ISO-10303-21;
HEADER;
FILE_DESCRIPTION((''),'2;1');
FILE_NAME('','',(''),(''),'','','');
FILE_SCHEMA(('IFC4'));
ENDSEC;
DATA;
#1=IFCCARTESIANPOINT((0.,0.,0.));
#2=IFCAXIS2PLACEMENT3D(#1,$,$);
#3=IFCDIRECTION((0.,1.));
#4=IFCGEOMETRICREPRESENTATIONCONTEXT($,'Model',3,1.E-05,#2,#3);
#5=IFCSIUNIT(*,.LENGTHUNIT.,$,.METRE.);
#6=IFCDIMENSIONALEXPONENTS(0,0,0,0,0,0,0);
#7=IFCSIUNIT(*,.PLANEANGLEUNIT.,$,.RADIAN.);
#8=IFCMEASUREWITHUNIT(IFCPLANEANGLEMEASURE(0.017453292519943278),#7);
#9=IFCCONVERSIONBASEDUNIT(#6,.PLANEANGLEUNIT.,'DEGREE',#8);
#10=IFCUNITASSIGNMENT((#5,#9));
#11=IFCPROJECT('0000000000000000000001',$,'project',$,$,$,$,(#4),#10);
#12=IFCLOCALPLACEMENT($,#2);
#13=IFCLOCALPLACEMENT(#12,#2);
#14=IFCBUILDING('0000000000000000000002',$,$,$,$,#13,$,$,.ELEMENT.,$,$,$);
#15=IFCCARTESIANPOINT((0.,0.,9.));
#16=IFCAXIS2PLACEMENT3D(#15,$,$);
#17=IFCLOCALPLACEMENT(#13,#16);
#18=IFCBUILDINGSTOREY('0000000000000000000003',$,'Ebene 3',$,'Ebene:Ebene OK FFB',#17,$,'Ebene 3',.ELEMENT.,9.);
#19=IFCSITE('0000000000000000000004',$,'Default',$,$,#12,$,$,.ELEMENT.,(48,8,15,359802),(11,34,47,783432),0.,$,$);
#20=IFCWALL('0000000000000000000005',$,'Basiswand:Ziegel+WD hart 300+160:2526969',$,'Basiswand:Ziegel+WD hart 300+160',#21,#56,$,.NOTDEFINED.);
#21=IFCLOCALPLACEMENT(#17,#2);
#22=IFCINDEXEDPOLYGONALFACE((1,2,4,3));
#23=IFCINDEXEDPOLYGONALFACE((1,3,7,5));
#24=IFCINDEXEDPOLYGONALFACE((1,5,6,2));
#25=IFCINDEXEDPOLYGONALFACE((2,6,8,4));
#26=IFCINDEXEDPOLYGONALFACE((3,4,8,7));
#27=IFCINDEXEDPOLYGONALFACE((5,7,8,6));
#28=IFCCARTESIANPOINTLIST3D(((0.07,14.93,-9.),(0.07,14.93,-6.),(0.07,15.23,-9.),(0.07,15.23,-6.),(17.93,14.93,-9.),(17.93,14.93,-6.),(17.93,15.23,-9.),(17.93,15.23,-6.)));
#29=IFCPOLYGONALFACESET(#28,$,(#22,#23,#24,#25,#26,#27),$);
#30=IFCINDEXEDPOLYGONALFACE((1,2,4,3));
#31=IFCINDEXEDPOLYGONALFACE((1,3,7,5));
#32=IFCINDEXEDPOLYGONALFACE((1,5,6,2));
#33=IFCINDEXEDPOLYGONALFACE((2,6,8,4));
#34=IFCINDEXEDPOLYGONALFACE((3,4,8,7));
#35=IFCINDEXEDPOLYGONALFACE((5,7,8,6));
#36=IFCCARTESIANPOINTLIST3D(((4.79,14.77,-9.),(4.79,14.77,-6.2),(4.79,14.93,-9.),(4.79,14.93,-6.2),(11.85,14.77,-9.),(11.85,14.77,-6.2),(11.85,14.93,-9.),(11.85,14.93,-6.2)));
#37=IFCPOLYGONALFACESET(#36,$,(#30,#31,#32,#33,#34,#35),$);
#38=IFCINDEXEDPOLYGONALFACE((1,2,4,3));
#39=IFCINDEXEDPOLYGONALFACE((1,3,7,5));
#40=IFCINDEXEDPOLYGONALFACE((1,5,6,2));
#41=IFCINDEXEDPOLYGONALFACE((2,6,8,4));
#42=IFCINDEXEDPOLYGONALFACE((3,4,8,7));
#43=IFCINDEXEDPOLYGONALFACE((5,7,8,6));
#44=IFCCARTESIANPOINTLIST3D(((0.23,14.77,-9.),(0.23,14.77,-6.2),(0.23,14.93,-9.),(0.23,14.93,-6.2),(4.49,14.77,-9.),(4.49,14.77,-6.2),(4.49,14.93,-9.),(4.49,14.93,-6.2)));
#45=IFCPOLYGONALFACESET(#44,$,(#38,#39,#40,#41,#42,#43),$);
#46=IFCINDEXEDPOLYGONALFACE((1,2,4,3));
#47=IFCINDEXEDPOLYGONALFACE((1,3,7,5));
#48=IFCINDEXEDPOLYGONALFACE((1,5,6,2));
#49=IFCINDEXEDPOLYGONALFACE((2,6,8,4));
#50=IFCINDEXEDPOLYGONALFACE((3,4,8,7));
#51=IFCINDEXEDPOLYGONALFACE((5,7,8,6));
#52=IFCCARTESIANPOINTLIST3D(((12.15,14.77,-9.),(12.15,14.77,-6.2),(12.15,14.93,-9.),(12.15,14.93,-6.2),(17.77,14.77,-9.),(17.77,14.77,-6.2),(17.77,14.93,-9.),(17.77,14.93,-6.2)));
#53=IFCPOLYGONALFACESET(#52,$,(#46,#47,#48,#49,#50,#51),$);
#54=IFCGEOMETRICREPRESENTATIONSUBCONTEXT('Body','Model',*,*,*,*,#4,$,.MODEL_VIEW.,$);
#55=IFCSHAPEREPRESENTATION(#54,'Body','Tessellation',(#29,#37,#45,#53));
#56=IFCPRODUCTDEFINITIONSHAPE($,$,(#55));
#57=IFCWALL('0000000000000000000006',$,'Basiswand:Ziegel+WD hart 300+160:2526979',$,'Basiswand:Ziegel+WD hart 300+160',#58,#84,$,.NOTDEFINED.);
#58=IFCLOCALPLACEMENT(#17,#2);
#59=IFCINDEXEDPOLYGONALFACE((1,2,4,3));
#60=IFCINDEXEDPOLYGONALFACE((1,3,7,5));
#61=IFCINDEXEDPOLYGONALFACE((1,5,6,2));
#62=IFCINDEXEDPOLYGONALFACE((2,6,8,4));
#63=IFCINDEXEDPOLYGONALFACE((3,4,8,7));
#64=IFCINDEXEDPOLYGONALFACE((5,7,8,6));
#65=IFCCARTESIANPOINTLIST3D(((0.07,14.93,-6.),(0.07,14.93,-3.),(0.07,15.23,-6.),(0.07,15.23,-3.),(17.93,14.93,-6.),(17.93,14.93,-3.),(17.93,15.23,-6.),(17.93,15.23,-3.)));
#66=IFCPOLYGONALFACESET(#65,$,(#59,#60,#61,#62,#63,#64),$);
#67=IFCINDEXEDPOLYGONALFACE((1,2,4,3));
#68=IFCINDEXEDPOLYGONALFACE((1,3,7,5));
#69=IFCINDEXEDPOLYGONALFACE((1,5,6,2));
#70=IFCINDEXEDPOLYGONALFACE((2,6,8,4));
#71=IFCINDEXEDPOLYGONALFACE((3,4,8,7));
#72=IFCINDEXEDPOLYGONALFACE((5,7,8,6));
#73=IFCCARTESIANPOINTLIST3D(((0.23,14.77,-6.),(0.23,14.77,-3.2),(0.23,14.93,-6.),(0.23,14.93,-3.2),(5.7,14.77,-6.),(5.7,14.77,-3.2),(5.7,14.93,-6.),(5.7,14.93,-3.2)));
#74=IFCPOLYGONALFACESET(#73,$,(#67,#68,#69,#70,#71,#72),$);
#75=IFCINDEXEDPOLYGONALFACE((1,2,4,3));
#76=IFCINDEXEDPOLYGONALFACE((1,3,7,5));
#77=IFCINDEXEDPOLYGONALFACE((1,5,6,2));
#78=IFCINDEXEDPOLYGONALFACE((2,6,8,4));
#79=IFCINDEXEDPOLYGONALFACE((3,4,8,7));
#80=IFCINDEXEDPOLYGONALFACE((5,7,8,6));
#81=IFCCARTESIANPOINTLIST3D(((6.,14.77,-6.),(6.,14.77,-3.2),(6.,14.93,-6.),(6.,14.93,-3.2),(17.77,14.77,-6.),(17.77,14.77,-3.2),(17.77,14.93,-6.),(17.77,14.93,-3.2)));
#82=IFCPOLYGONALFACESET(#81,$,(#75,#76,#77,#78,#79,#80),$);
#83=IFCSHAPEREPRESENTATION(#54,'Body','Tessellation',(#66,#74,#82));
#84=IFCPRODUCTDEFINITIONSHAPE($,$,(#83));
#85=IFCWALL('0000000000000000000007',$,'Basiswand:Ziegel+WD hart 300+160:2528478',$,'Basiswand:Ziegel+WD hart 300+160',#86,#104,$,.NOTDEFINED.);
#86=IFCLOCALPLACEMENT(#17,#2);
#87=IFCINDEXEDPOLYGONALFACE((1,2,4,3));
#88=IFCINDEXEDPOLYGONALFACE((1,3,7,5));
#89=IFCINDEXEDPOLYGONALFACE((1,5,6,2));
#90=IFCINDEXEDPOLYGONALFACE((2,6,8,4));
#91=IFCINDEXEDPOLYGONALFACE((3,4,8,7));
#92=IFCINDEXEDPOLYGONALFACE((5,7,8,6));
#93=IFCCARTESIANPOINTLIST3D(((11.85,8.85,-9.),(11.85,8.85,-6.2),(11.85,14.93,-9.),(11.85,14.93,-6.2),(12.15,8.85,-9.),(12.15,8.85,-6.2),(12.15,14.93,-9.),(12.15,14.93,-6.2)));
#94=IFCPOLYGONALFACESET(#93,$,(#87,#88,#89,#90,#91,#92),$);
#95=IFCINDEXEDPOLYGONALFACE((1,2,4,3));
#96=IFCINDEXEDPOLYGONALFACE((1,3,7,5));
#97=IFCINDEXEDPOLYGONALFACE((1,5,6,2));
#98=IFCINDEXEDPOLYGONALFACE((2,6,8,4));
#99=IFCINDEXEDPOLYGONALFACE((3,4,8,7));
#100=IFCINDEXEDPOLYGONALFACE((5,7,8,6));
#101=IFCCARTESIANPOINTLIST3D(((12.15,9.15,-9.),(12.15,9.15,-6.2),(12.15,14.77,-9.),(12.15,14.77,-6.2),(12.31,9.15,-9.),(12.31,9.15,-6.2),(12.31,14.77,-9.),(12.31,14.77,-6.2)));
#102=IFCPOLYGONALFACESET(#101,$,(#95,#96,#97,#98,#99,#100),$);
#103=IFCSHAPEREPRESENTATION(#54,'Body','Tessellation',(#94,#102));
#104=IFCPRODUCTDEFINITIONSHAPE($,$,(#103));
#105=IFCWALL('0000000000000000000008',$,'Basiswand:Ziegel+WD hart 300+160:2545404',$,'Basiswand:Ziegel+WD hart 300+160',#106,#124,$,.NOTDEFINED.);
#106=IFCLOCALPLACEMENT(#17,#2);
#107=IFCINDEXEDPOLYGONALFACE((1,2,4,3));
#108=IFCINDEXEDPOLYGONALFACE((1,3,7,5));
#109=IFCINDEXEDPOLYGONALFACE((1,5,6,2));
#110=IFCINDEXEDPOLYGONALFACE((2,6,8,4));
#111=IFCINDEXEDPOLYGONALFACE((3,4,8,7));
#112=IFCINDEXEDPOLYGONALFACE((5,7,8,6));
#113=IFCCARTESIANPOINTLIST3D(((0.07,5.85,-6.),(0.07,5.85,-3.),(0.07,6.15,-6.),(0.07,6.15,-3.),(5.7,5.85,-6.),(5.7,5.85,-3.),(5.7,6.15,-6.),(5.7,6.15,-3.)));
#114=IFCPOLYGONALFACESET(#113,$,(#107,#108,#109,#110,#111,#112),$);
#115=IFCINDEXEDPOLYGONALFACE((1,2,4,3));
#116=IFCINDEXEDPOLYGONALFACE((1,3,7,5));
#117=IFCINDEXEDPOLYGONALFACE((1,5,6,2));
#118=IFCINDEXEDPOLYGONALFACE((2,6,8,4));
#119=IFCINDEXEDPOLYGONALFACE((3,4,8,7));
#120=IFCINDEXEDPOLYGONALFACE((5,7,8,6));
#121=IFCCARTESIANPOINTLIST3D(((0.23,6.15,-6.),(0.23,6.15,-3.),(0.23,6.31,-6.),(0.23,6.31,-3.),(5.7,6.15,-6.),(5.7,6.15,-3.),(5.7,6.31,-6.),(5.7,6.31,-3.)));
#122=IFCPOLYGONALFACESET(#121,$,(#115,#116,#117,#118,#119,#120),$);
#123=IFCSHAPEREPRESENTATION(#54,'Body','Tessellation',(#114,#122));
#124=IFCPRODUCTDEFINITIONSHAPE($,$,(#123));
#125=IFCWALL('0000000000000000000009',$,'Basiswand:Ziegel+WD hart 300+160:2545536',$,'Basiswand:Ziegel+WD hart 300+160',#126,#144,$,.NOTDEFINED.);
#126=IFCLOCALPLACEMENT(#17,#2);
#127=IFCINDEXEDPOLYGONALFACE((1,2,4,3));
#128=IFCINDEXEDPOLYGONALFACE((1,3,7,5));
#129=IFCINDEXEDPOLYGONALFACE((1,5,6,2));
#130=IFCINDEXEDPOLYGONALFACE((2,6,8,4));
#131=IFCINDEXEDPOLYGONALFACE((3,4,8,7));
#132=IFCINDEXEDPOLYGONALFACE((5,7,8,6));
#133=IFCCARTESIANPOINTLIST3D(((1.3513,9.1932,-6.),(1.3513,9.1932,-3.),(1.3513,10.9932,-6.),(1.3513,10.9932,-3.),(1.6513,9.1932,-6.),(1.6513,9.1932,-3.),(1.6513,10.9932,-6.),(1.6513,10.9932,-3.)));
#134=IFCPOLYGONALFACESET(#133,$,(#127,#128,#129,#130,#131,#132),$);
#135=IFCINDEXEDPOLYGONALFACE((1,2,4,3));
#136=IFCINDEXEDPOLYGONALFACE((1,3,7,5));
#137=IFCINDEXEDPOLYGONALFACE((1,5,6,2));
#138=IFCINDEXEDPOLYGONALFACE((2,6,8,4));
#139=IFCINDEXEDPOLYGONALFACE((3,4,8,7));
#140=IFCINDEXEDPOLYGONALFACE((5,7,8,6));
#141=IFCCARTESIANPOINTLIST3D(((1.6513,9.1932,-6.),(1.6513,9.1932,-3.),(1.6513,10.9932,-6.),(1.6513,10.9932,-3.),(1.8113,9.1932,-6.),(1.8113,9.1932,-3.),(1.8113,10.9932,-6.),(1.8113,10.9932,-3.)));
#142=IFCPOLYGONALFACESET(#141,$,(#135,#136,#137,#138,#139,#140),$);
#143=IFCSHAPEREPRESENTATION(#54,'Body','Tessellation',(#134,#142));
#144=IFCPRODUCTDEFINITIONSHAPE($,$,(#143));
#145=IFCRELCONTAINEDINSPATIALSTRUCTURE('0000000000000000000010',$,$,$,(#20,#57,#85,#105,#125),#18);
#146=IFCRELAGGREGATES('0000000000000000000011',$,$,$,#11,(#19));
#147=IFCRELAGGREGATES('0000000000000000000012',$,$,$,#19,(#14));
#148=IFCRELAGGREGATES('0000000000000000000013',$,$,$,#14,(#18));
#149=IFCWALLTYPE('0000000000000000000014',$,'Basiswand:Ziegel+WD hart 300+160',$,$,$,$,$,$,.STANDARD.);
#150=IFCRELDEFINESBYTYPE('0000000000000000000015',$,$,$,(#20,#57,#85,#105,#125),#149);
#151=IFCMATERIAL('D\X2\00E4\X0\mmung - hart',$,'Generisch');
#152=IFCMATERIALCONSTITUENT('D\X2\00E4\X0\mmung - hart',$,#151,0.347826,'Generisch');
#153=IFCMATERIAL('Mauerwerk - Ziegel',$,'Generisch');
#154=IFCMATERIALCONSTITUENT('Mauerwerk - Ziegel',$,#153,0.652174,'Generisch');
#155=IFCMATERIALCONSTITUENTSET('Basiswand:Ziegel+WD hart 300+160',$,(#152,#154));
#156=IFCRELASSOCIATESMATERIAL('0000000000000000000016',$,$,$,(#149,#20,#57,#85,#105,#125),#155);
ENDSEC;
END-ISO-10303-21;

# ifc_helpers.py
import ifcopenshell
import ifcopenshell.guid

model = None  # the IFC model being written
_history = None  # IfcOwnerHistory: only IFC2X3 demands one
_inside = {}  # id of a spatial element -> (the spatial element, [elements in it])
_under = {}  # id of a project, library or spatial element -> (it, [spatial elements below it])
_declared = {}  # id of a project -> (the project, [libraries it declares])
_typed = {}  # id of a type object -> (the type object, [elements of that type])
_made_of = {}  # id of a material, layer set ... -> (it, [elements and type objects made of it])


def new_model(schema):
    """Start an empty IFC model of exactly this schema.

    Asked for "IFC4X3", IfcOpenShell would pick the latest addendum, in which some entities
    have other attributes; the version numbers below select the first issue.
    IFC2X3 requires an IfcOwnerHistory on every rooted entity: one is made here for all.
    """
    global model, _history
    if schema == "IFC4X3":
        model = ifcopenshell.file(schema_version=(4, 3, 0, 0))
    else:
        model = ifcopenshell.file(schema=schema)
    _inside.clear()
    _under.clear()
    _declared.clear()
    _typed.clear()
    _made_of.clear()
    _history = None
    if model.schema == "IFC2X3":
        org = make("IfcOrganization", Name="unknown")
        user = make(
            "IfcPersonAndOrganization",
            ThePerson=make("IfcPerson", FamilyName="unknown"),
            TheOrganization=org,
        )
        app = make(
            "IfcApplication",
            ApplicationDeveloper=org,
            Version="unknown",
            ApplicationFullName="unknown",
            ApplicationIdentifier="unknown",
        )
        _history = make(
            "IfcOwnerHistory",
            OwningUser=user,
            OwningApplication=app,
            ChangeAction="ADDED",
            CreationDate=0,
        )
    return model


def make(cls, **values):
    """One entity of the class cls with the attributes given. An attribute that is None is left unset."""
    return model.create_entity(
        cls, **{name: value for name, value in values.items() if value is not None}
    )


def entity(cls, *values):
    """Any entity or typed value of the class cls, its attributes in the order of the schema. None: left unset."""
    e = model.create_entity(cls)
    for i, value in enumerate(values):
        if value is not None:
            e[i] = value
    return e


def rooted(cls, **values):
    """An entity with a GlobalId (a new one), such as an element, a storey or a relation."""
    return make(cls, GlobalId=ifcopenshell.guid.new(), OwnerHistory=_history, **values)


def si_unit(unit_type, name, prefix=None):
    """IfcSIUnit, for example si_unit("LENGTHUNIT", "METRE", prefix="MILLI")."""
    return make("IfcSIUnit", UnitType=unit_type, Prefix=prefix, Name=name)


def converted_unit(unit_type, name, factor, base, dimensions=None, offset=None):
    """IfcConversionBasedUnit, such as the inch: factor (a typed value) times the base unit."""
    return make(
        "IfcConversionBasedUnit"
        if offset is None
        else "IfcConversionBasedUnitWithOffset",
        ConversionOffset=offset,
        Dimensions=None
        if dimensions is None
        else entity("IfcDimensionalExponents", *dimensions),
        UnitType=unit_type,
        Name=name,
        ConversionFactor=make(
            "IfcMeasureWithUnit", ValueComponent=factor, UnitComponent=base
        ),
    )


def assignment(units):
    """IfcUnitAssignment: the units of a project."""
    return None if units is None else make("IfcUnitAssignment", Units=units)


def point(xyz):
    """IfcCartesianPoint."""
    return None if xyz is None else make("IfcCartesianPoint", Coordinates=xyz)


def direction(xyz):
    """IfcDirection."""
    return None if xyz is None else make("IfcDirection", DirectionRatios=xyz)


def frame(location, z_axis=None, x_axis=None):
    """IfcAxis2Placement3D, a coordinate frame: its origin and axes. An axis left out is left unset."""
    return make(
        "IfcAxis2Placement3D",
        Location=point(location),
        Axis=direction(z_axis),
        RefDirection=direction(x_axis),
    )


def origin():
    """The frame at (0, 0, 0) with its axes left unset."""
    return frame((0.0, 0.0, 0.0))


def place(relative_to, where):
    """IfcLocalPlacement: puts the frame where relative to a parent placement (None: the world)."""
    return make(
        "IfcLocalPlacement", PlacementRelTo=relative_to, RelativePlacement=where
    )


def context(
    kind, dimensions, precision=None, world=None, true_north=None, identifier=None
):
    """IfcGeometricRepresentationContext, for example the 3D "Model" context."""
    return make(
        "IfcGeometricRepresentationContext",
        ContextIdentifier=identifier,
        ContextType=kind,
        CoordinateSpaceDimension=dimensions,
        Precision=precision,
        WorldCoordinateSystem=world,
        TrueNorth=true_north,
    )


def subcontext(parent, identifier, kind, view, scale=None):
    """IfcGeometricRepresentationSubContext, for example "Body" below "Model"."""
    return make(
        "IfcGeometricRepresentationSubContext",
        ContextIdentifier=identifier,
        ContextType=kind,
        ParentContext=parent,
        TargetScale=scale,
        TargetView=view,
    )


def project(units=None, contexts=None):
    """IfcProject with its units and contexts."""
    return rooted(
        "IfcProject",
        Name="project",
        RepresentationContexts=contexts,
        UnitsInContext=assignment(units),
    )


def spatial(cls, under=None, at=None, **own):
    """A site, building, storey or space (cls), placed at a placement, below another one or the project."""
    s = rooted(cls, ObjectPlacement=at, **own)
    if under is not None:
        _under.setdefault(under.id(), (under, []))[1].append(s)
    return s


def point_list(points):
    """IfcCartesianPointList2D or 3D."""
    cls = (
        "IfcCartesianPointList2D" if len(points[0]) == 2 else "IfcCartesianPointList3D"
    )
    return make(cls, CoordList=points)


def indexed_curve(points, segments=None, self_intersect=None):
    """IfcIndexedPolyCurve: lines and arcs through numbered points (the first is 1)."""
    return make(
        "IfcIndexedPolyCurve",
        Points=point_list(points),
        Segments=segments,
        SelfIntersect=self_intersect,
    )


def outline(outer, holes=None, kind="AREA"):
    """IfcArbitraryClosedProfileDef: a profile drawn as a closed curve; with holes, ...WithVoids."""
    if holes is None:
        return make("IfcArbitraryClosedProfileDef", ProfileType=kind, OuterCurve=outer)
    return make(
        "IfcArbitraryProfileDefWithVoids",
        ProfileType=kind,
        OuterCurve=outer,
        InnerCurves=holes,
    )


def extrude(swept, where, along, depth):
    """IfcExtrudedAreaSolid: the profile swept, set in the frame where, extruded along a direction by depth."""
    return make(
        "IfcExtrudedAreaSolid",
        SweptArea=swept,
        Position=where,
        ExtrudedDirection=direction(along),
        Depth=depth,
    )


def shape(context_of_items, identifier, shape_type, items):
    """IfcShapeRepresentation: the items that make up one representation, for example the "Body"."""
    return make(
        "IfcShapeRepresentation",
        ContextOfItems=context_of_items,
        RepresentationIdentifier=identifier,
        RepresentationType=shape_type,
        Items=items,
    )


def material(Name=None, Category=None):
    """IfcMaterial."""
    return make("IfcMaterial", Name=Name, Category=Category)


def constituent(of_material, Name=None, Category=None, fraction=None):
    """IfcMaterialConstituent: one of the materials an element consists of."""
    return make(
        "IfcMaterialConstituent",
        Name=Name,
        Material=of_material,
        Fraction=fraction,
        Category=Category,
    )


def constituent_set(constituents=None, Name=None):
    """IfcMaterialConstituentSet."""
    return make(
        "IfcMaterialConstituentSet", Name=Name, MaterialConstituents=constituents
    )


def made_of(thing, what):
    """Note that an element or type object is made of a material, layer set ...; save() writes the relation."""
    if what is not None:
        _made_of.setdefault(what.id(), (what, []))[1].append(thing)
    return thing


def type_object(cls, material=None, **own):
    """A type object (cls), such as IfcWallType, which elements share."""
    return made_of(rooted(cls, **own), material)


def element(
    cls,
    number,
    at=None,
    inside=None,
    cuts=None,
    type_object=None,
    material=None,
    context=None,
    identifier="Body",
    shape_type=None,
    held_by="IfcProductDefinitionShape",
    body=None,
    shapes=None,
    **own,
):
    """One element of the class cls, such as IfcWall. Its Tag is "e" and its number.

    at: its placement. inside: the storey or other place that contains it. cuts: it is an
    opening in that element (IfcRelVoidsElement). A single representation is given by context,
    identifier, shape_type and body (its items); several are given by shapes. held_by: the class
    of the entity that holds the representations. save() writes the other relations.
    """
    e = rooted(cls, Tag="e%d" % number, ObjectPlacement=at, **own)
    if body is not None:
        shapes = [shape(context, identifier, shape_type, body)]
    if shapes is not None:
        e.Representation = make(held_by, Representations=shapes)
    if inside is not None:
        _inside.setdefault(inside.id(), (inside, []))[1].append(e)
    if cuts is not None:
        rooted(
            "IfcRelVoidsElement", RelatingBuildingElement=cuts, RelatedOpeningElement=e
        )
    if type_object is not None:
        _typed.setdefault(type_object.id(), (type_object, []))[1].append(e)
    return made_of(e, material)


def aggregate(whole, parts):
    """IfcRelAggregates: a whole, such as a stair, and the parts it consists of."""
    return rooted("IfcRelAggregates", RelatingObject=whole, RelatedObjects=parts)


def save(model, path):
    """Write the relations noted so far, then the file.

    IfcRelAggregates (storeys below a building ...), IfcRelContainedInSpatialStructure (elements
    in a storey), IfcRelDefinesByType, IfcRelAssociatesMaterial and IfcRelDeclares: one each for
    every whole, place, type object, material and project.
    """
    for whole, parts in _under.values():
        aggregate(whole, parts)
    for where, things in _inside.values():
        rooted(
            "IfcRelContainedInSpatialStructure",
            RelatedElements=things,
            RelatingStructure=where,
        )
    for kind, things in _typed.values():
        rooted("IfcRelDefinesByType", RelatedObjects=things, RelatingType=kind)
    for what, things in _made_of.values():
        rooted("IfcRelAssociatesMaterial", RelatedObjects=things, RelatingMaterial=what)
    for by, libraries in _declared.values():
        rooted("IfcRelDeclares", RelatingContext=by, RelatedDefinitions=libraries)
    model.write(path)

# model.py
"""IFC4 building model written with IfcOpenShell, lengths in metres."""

from ifc_helpers import new_model, entity, si_unit, converted_unit, direction, frame, origin, place, context, subcontext, project, spatial, indexed_curve, outline, extrude, material, constituent, constituent_set, type_object, element, save


model = new_model("IFC4")

# Units and contexts
model_context = context("Model", 3, precision=1e-05, world=origin(), true_north=direction((0.0, 1.0)))
body_context = subcontext(model_context, "Body", "Model", "MODEL_VIEW")
ifc_project = project(units=[si_unit("LENGTHUNIT", "METRE"), converted_unit("PLANEANGLEUNIT", "DEGREE", entity("IfcPlaneAngleMeasure", 0.017453292519943278), si_unit("PLANEANGLEUNIT", "RADIAN"), dimensions=[0, 0, 0, 0, 0, 0, 0])], contexts=[model_context])

# Site, building, storey
site_placement = place(None, origin())
site = spatial("IfcSite", under=ifc_project, at=site_placement, Name="Default", CompositionType="ELEMENT", RefLatitude=(48, 8, 15, 359802), RefLongitude=(11, 34, 47, 783432), RefElevation=0.0)
building_placement = place(site_placement, origin())
building = spatial("IfcBuilding", under=site, at=building_placement, CompositionType="ELEMENT")
storey_placement = place(building_placement, frame((0.0, 0.0, 9.0)))
storey = spatial("IfcBuildingStorey", under=building, at=storey_placement, Name="Ebene 3", ObjectType="Ebene:Ebene OK FFB", LongName="Ebene 3", CompositionType="ELEMENT", Elevation=9.0)

# Walls
ifc_material_1 = material(Name="Dämmung - hart", Category="Generisch")
ifc_constituent_1 = constituent(ifc_material_1, Name="Dämmung - hart", Category="Generisch", fraction=0.347826)
ifc_material_2 = material(Name="Mauerwerk - Ziegel", Category="Generisch")
ifc_constituent_2 = constituent(ifc_material_2, Name="Mauerwerk - Ziegel", Category="Generisch", fraction=0.652174)
ifc_constituent_set_1 = constituent_set(constituents=[ifc_constituent_1, ifc_constituent_2], Name="Basiswand:Ziegel+WD hart 300+160")
wall_type = type_object("IfcWallType", Name="Basiswand:Ziegel+WD hart 300+160", PredefinedType="STANDARD", material=ifc_constituent_set_1)
wall_1_placement = place(storey_placement, frame((17.77, 15.0, -9.0), z_axis=(0.0, 0.0, 1.0), x_axis=(-1.0, 0.0, 0.0)))
element("IfcWall", 1, at=wall_1_placement, inside=storey, type_object=wall_type, material=ifc_constituent_set_1, Name="Basiswand:Ziegel+WD hart 300+160:2526969", ObjectType="Basiswand:Ziegel+WD hart 300+160", PredefinedType="NOTDEFINED", context=body_context, shape_type="SweptSolid", body=[
    extrude(outline(indexed_curve([(-0.15, -8.93), (0.15, -8.93), (0.15, 8.93), (-0.15, 8.93), (-0.15, -8.93)], self_intersect=False)), frame((8.77, -0.08, 0.0), z_axis=(0.0, 0.0, 1.0), x_axis=(0.0, 1.0, 0.0)), (0.0, 0.0, 1.0), 3.0),
    extrude(outline(indexed_curve([(-3.53, -0.08), (3.53, -0.08), (3.53, 0.08), (-3.53, 0.08), (-3.53, -0.08)], self_intersect=False)), frame((9.45, 0.15, 0.0)), (0.0, 0.0, 1.0), 2.8),
    extrude(outline(indexed_curve([(-2.13, -0.08), (2.13, -0.08), (2.13, 0.08), (-2.13, 0.08), (-2.13, -0.08)], self_intersect=False)), frame((15.41, 0.15, 0.0), z_axis=(0.0, 0.0, 1.0), x_axis=(-1.0, 0.0, 0.0)), (0.0, 0.0, 1.0), 2.8),
    extrude(outline(indexed_curve([(-2.81, -0.08), (2.81, -0.08), (2.81, 0.08), (-2.81, 0.08), (-2.81, -0.08)], self_intersect=False)), frame((2.81, 0.15, 0.0)), (0.0, 0.0, 1.0), 2.8),
])
wall_2_placement = place(storey_placement, frame((17.77, 15.0, -6.0), z_axis=(0.0, 0.0, 1.0), x_axis=(-1.0, 0.0, 0.0)))
element("IfcWall", 2, at=wall_2_placement, inside=storey, type_object=wall_type, material=ifc_constituent_set_1, Name="Basiswand:Ziegel+WD hart 300+160:2526979", ObjectType="Basiswand:Ziegel+WD hart 300+160", PredefinedType="NOTDEFINED", context=body_context, shape_type="SweptSolid", body=[
    extrude(outline(indexed_curve([(-0.15, -8.93), (0.15, -8.93), (0.15, 8.93), (-0.15, 8.93), (-0.15, -8.93)], self_intersect=False)), frame((8.77, -0.08, 0.0), z_axis=(0.0, 0.0, 1.0), x_axis=(0.0, 1.0, 0.0)), (0.0, 0.0, 1.0), 3.0),
    extrude(outline(indexed_curve([(-2.735, -0.08), (2.735, -0.08), (2.735, 0.08), (-2.735, 0.08), (-2.735, -0.08)], self_intersect=False)), frame((14.805, 0.15, 0.0), z_axis=(0.0, 0.0, 1.0), x_axis=(-1.0, 0.0, 0.0)), (0.0, 0.0, 1.0), 2.8),
    extrude(outline(indexed_curve([(-5.885, -0.08), (5.885, -0.08), (5.885, 0.08), (-5.885, 0.08), (-5.885, -0.08)], self_intersect=False)), frame((5.885, 0.15, 0.0)), (0.0, 0.0, 1.0), 2.8),
])

# Wall
wall_3_placement = place(storey_placement, frame((12.08, 14.77, -9.0), z_axis=(0.0, 0.0, 1.0), x_axis=(0.0, -1.0, 0.0)))
element("IfcWall", 3, at=wall_3_placement, inside=storey, type_object=wall_type, material=ifc_constituent_set_1, Name="Basiswand:Ziegel+WD hart 300+160:2528478", ObjectType="Basiswand:Ziegel+WD hart 300+160", PredefinedType="NOTDEFINED", context=body_context, shape_type="SweptSolid", body=[
    extrude(outline(indexed_curve([(-1.4, -3.04), (1.4, -3.04), (1.4, 3.04), (-1.4, 3.04), (-1.4, -3.04)], self_intersect=False)), frame((2.88, -0.23, 1.4), z_axis=(0.0, 1.0, 0.0), x_axis=(0.0, 0.0, 1.0)), (0.0, 0.0, 1.0), 0.3),
    extrude(outline(indexed_curve([(-1.4, -2.81), (1.4, -2.81), (1.4, 2.81), (-1.4, 2.81), (-1.4, -2.81)], self_intersect=False)), frame((2.81, 0.07, 1.4), z_axis=(0.0, 1.0, 0.0), x_axis=(0.0, 0.0, 1.0)), (0.0, 0.0, 1.0), 0.16),
])

# Walls
wall_4_placement = place(storey_placement, frame((0.23, 6.08, -6.0)))
element("IfcWall", 4, at=wall_4_placement, inside=storey, type_object=wall_type, material=ifc_constituent_set_1, Name="Basiswand:Ziegel+WD hart 300+160:2545404", ObjectType="Basiswand:Ziegel+WD hart 300+160", PredefinedType="NOTDEFINED", context=body_context, shape_type="SweptSolid", body=[
    extrude(outline(indexed_curve([(-0.15, -2.815), (0.15, -2.815), (0.15, 2.815), (-0.15, 2.815), (-0.15, -2.815)], self_intersect=False)), frame((2.655, -0.08, 0.0), z_axis=(0.0, 0.0, 1.0), x_axis=(0.0, 1.0, 0.0)), (0.0, 0.0, 1.0), 3.0),
    extrude(outline(indexed_curve([(-0.08, -2.735), (0.08, -2.735), (0.08, 2.735), (-0.08, 2.735), (-0.08, -2.735)], self_intersect=False)), frame((2.735, 0.15, 0.0), z_axis=(0.0, 0.0, 1.0), x_axis=(0.0, 1.0, 0.0)), (0.0, 0.0, 1.0), 3.0),
])
wall_5_placement = place(storey_placement, frame((1.5813, 10.9932, -6.0), z_axis=(0.0, 0.0, 1.0), x_axis=(0.0, -1.0, 0.0)))
element("IfcWall", 5, at=wall_5_placement, inside=storey, type_object=wall_type, material=ifc_constituent_set_1, Name="Basiswand:Ziegel+WD hart 300+160:2545536", ObjectType="Basiswand:Ziegel+WD hart 300+160", PredefinedType="NOTDEFINED", context=body_context, shape_type="SweptSolid", body=[
    extrude(outline(indexed_curve([(-0.15, -0.9), (0.15, -0.9), (0.15, 0.9), (-0.15, 0.9), (-0.15, -0.9)], self_intersect=False)), frame((0.9, -0.08, 0.0), z_axis=(0.0, 0.0, 1.0), x_axis=(0.0, 1.0, 0.0)), (0.0, 0.0, 1.0), 3.0),
    extrude(outline(indexed_curve([(-0.08, -0.9), (0.08, -0.9), (0.08, 0.9), (-0.08, 0.9), (-0.08, -0.9)], self_intersect=False)), frame((0.9, 0.15, 0.0), z_axis=(0.0, 0.0, 1.0), x_axis=(0.0, -1.0, 0.0)), (0.0, 0.0, 1.0), 3.0),
])

save(model, "model.ifc")
